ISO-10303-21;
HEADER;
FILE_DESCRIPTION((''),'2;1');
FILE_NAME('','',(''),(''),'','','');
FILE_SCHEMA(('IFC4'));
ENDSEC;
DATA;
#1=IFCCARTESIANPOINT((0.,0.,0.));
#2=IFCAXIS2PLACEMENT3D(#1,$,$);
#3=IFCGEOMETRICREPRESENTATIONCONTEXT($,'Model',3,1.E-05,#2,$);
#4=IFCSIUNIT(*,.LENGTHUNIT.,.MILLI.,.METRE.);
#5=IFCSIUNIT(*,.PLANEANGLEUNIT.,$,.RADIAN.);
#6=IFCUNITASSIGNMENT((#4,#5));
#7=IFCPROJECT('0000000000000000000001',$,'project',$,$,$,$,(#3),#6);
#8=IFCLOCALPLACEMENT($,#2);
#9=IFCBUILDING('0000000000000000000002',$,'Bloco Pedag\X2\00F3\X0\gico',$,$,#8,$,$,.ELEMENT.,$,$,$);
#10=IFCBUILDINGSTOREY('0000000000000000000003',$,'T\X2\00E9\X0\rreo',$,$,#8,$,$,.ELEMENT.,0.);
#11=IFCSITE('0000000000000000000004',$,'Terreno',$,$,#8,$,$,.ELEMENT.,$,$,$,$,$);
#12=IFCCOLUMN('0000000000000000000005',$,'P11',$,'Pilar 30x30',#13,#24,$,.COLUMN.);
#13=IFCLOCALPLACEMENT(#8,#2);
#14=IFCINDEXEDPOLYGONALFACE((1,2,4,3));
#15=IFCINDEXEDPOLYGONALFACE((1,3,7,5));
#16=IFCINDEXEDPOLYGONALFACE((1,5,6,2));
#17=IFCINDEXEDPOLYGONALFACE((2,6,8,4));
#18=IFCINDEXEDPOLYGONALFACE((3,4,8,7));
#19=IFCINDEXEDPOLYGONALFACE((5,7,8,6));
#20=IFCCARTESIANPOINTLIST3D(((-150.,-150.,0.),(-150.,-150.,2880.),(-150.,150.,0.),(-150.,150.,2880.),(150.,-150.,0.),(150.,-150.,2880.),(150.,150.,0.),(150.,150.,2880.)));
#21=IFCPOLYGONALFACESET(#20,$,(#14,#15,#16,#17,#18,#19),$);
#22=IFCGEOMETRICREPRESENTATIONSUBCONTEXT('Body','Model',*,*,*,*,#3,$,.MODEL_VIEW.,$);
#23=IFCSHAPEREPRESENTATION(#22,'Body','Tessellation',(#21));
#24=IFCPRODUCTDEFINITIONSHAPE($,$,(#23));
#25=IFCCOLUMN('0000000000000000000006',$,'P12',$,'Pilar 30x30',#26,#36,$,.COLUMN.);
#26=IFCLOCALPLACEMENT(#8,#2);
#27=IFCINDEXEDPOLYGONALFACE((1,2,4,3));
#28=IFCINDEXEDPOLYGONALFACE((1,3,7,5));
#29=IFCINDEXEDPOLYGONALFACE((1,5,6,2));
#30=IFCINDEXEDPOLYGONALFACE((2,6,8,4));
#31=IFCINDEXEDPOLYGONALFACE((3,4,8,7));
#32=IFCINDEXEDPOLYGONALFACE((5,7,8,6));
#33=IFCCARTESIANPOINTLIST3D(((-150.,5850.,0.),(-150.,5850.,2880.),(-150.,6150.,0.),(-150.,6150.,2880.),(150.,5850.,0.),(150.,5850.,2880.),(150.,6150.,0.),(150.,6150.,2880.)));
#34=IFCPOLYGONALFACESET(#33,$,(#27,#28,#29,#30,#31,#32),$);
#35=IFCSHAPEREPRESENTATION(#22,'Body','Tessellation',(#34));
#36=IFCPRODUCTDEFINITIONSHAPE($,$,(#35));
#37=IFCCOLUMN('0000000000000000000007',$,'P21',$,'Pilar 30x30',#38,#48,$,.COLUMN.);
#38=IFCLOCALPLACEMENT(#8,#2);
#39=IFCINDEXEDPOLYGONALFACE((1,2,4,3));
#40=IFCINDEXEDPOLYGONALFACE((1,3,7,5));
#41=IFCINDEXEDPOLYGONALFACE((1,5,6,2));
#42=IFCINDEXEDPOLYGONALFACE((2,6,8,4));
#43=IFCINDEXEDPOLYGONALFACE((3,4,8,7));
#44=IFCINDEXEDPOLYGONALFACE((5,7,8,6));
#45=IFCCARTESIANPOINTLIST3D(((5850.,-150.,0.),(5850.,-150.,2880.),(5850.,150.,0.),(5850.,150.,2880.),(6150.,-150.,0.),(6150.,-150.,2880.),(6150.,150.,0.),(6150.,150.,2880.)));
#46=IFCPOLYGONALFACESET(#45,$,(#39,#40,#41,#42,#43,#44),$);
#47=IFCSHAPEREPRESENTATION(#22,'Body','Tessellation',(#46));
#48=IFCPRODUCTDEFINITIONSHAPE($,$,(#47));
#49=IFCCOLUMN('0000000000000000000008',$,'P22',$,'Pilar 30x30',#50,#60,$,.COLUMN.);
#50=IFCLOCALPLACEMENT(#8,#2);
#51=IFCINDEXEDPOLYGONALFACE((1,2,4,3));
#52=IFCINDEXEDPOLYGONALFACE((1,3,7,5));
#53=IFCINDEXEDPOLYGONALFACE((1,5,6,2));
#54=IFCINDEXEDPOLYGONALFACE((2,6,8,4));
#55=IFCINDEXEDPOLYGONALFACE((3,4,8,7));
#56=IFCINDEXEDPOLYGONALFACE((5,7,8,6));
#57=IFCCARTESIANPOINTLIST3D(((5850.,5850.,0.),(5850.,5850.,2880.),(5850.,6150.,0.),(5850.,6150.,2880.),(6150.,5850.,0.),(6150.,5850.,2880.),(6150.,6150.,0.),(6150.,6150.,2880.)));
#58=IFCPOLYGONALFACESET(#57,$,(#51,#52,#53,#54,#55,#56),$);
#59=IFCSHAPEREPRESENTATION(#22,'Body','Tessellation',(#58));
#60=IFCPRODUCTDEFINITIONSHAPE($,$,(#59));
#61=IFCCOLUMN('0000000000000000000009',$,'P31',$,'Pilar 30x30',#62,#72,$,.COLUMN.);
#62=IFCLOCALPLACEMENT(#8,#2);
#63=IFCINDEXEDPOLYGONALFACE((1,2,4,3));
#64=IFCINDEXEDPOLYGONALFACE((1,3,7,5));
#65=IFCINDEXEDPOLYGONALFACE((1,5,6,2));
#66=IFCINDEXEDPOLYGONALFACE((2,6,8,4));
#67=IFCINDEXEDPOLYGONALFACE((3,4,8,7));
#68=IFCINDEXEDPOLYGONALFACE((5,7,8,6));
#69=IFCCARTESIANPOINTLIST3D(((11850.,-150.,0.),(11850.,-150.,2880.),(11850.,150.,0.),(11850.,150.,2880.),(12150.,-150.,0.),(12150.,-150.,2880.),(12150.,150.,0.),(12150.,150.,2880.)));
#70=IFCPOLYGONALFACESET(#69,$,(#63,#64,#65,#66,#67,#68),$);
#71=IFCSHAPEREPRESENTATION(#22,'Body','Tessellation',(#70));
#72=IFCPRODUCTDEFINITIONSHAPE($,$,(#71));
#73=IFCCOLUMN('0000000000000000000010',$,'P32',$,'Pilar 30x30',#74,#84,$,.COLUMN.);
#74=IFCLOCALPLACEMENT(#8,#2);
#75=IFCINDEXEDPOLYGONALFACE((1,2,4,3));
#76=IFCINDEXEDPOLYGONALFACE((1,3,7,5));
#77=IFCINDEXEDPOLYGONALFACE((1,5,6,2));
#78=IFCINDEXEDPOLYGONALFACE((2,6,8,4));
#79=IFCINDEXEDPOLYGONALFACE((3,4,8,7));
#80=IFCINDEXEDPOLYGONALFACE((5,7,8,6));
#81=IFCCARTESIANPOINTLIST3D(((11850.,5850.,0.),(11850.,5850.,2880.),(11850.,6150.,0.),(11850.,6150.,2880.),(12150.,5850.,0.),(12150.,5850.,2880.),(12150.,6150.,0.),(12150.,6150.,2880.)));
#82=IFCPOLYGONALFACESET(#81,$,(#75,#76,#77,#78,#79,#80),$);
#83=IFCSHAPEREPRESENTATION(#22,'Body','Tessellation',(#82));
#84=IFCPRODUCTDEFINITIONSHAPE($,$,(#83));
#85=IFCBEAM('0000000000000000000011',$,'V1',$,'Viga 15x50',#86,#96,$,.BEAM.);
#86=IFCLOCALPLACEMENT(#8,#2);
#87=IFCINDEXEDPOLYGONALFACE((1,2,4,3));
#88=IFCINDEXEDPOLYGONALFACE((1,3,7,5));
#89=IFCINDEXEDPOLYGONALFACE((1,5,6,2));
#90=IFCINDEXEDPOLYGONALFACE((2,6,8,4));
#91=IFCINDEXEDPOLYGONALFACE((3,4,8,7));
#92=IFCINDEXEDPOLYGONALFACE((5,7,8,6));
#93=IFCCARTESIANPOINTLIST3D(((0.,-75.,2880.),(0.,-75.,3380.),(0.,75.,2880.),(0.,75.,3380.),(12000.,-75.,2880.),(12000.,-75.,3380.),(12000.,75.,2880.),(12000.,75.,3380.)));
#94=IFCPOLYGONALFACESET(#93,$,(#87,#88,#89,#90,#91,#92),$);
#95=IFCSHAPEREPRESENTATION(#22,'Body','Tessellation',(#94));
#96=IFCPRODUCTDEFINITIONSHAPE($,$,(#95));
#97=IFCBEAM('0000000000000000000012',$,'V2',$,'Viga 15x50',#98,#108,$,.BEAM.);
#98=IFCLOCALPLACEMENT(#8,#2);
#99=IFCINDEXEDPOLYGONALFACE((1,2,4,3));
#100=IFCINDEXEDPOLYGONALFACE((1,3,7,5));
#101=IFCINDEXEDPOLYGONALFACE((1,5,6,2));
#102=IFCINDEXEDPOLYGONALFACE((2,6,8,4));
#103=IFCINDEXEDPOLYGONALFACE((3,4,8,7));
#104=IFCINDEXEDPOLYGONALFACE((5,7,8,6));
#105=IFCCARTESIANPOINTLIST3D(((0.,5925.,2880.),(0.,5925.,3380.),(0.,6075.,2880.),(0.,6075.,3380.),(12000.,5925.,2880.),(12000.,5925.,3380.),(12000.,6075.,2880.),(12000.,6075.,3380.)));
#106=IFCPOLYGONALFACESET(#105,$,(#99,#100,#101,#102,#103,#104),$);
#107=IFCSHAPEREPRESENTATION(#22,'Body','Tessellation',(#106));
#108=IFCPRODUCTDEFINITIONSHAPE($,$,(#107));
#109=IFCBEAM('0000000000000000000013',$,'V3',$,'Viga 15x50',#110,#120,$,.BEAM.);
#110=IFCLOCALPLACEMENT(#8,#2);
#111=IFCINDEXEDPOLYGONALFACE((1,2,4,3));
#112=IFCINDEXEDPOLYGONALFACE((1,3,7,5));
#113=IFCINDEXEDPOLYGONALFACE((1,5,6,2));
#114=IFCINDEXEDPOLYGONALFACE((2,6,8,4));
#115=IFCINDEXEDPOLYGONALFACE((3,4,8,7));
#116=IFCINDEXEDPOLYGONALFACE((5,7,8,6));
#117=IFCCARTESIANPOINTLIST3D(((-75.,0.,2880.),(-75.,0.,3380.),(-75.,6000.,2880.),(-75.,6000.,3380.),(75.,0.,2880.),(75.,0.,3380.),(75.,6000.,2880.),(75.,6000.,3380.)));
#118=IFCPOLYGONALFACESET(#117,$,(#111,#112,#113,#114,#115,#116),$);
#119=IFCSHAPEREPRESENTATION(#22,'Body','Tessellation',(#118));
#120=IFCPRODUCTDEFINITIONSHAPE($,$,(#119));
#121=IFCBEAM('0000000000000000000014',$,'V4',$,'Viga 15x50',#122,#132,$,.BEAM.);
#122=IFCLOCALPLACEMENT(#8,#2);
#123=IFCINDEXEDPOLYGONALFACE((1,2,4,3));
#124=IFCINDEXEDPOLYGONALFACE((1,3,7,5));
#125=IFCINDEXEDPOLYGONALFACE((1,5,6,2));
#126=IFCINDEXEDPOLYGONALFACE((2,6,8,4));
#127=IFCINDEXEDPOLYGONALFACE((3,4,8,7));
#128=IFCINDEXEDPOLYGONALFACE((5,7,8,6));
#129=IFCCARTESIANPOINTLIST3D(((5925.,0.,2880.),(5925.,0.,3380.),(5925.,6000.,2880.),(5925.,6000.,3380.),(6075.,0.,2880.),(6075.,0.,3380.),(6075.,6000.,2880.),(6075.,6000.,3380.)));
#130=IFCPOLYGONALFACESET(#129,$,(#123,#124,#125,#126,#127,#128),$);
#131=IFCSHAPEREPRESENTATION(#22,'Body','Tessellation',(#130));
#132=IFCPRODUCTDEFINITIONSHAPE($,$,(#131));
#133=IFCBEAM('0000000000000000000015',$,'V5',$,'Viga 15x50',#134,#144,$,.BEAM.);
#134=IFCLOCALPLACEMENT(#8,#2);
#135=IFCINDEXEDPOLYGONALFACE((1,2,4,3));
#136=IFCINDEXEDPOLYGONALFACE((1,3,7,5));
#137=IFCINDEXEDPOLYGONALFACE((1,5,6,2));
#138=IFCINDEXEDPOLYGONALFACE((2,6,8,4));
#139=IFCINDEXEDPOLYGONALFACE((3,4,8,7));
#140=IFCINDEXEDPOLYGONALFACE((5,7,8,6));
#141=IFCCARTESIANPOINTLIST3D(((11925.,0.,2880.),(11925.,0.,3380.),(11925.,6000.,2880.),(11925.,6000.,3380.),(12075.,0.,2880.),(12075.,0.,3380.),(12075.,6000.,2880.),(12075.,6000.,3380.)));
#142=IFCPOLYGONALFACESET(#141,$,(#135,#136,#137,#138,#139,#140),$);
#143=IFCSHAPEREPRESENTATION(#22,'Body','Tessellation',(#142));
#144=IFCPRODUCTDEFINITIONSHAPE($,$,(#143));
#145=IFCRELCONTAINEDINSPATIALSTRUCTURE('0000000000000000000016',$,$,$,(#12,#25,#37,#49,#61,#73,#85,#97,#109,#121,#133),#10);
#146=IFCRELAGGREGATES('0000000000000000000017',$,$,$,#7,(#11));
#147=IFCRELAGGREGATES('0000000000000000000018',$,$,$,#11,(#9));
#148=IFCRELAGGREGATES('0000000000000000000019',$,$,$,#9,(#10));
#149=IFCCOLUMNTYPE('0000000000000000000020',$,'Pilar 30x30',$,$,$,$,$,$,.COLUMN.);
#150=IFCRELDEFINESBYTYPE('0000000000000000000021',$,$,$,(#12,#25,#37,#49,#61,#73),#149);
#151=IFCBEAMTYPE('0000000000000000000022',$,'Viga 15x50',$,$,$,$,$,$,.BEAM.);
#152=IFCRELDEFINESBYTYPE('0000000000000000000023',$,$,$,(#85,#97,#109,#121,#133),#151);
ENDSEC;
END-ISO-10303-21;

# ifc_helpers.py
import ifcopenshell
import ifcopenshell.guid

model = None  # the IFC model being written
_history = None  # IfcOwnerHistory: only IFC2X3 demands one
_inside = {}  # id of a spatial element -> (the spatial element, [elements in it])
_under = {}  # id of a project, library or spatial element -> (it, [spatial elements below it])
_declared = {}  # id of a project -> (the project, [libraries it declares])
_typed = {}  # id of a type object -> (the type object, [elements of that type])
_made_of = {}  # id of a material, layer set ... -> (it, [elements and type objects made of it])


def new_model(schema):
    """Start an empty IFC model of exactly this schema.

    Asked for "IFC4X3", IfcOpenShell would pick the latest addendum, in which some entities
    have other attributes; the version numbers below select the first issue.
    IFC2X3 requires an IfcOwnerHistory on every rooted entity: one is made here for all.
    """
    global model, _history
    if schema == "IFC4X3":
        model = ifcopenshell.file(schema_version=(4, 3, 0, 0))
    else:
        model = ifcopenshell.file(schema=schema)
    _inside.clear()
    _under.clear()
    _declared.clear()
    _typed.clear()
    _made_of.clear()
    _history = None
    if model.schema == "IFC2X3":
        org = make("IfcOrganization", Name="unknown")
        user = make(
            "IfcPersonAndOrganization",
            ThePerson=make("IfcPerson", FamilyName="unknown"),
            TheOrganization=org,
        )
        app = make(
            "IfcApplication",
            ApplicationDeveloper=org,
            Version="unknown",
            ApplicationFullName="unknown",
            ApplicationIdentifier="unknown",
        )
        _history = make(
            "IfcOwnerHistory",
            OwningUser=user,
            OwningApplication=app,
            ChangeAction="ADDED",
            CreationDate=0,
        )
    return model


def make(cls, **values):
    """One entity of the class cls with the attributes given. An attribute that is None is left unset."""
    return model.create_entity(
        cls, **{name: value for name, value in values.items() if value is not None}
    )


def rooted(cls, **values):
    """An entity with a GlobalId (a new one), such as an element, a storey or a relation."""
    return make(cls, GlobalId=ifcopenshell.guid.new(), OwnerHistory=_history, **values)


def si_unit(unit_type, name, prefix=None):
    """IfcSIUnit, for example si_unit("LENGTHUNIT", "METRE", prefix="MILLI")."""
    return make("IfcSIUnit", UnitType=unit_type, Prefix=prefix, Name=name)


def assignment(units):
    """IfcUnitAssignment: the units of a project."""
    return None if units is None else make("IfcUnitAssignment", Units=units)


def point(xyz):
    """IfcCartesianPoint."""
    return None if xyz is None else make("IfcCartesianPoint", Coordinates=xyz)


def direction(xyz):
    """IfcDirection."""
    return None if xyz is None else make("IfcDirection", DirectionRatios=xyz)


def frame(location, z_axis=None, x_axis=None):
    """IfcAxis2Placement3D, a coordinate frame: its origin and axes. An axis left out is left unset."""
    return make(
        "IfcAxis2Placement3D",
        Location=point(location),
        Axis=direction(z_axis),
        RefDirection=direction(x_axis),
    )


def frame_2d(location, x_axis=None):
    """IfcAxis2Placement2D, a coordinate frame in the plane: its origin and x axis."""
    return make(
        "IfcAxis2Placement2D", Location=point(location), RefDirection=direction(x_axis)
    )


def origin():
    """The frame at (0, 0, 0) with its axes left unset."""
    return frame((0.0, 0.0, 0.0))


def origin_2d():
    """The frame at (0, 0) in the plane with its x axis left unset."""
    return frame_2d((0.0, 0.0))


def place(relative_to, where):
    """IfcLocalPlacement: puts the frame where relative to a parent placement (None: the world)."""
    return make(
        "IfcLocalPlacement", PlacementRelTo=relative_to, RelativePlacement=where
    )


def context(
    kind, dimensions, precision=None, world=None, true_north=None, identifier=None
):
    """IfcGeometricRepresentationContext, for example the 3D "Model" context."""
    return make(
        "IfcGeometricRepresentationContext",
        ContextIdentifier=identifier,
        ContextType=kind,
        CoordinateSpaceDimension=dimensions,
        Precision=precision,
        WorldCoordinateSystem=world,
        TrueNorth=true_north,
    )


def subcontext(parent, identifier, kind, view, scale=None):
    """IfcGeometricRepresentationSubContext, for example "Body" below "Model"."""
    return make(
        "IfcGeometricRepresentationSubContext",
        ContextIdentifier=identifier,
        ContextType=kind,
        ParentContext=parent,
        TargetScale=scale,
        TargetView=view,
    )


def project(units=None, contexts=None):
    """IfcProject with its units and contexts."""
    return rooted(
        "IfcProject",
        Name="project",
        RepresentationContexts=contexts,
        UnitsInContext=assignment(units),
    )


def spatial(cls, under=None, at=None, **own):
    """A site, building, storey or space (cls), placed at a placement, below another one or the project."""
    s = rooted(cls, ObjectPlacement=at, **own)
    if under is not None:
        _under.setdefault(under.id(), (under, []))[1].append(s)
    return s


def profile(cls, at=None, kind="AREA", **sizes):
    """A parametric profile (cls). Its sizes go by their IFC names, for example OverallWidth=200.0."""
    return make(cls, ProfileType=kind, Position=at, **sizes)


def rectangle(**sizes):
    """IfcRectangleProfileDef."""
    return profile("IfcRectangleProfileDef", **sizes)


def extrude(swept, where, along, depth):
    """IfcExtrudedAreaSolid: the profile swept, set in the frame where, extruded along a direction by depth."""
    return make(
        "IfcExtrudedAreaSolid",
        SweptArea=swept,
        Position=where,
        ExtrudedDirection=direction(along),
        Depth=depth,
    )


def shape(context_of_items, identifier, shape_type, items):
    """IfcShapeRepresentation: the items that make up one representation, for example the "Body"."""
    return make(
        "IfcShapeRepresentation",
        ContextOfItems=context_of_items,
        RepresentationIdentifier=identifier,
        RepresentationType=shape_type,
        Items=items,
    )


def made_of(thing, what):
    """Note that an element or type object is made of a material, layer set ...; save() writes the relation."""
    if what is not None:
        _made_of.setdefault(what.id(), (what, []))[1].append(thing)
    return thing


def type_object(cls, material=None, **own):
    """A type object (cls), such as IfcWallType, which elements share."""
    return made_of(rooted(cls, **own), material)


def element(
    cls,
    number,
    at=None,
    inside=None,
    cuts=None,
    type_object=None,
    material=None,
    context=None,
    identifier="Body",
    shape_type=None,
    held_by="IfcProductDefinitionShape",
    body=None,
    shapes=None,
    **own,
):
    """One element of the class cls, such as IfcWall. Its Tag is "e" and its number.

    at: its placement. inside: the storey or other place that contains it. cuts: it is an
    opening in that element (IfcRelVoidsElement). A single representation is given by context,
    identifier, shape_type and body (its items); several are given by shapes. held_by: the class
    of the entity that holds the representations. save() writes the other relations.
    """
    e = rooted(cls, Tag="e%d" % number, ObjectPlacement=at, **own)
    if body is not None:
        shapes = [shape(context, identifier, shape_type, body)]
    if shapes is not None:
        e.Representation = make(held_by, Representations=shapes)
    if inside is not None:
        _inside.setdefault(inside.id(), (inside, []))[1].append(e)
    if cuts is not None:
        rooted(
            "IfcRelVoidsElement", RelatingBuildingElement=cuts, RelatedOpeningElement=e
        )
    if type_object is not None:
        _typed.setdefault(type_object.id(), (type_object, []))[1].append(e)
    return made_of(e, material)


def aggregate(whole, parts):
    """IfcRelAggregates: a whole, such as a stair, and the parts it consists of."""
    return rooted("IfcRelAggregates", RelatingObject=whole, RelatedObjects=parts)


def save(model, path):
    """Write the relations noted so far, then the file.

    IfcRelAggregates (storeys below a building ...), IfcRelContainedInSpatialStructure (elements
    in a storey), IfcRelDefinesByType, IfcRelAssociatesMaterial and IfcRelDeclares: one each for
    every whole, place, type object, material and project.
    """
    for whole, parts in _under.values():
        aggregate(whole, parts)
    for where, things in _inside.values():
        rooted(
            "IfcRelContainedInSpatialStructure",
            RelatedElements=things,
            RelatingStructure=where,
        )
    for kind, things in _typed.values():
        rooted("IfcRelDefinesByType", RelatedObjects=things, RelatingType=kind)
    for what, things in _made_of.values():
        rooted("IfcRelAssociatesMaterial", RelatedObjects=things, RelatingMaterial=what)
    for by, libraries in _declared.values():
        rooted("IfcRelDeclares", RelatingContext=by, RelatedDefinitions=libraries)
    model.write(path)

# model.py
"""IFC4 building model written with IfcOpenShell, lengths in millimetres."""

from ifc_helpers import new_model, si_unit, frame, origin, origin_2d, place, context, subcontext, project, spatial, rectangle, extrude, type_object, element, save


model = new_model("IFC4")

# Units and contexts
model_context = context("Model", 3, precision=1e-05, world=origin())
body_context = subcontext(model_context, "Body", "Model", "MODEL_VIEW")
ifc_project = project(units=[si_unit("LENGTHUNIT", "METRE", prefix="MILLI"), si_unit("PLANEANGLEUNIT", "RADIAN")], contexts=[model_context])

# Site, building, storey
placement = place(None, origin())
site = spatial("IfcSite", under=ifc_project, at=placement, Name="Terreno", CompositionType="ELEMENT")
building = spatial("IfcBuilding", under=site, at=placement, Name="Bloco Pedagógico", CompositionType="ELEMENT")
storey = spatial("IfcBuildingStorey", under=building, at=placement, Name="Térreo", CompositionType="ELEMENT", Elevation=0.0)

# Columns
column_type = type_object("IfcColumnType", Name="Pilar 30x30", PredefinedType="COLUMN")
for number, where, z_axis, x_axis, name in (
    (1, (0.0, 0.0, 0.0), (0.0, 0.0, 1.0), (1.0, 0.0, 0.0), "P11"),
    (2, (0.0, 6000.0, 0.0), (0.0, 0.0, 1.0), (1.0, 0.0, 0.0), "P12"),
    (3, (6000.0, 0.0, 0.0), (0.0, 0.0, 1.0), (1.0, 0.0, 0.0), "P21"),
    (4, (6000.0, 6000.0, 0.0), (0.0, 0.0, 1.0), (1.0, 0.0, 0.0), "P22"),
    (5, (12000.0, 0.0, 0.0), (0.0, 0.0, 1.0), (1.0, 0.0, 0.0), "P31"),
    (6, (12000.0, 6000.0, 0.0), (0.0, 0.0, 1.0), (1.0, 0.0, 0.0), "P32"),
):
    element("IfcColumn", number, at=place(None, frame(where, z_axis=z_axis, x_axis=x_axis)), inside=storey, type_object=column_type, Name=name, ObjectType="Pilar 30x30", PredefinedType="COLUMN", context=body_context, shape_type="SweptSolid", body=[
        extrude(rectangle(XDim=300.0, YDim=300.0, at=origin_2d()), None, (0.0, 0.0, 1.0), 2880.0),
    ])

# Beams
beam_type = type_object("IfcBeamType", Name="Viga 15x50", PredefinedType="BEAM")
for number, where, z_axis, x_axis, name in (
    (7, (0.0, 0.0, 3130.0), (1.0, 0.0, 0.0), (0.0, 1.0, 0.0), "V1"),
    (8, (0.0, 6000.0, 3130.0), (1.0, 0.0, 0.0), (0.0, 1.0, 0.0), "V2"),
):
    element("IfcBeam", number, at=place(None, frame(where, z_axis=z_axis, x_axis=x_axis)), inside=storey, type_object=beam_type, Name=name, ObjectType="Viga 15x50", PredefinedType="BEAM", context=body_context, shape_type="SweptSolid", body=[
        extrude(rectangle(XDim=150.0, YDim=500.0, at=origin_2d()), None, (0.0, 0.0, 1.0), 12000.0),
    ])
for number, where, z_axis, x_axis, name in (
    (9, (0.0, 0.0, 3130.0), (0.0, 1.0, 0.0), (1.0, 0.0, 0.0), "V3"),
    (10, (6000.0, 0.0, 3130.0), (0.0, 1.0, 0.0), (1.0, 0.0, 0.0), "V4"),
    (11, (12000.0, 0.0, 3130.0), (0.0, 1.0, 0.0), (1.0, 0.0, 0.0), "V5"),
):
    element("IfcBeam", number, at=place(None, frame(where, z_axis=z_axis, x_axis=x_axis)), inside=storey, type_object=beam_type, Name=name, ObjectType="Viga 15x50", PredefinedType="BEAM", context=body_context, shape_type="SweptSolid", body=[
        extrude(rectangle(XDim=150.0, YDim=500.0, at=origin_2d()), None, (0.0, 0.0, 1.0), 6000.0),
    ])

save(model, "model.ifc")
